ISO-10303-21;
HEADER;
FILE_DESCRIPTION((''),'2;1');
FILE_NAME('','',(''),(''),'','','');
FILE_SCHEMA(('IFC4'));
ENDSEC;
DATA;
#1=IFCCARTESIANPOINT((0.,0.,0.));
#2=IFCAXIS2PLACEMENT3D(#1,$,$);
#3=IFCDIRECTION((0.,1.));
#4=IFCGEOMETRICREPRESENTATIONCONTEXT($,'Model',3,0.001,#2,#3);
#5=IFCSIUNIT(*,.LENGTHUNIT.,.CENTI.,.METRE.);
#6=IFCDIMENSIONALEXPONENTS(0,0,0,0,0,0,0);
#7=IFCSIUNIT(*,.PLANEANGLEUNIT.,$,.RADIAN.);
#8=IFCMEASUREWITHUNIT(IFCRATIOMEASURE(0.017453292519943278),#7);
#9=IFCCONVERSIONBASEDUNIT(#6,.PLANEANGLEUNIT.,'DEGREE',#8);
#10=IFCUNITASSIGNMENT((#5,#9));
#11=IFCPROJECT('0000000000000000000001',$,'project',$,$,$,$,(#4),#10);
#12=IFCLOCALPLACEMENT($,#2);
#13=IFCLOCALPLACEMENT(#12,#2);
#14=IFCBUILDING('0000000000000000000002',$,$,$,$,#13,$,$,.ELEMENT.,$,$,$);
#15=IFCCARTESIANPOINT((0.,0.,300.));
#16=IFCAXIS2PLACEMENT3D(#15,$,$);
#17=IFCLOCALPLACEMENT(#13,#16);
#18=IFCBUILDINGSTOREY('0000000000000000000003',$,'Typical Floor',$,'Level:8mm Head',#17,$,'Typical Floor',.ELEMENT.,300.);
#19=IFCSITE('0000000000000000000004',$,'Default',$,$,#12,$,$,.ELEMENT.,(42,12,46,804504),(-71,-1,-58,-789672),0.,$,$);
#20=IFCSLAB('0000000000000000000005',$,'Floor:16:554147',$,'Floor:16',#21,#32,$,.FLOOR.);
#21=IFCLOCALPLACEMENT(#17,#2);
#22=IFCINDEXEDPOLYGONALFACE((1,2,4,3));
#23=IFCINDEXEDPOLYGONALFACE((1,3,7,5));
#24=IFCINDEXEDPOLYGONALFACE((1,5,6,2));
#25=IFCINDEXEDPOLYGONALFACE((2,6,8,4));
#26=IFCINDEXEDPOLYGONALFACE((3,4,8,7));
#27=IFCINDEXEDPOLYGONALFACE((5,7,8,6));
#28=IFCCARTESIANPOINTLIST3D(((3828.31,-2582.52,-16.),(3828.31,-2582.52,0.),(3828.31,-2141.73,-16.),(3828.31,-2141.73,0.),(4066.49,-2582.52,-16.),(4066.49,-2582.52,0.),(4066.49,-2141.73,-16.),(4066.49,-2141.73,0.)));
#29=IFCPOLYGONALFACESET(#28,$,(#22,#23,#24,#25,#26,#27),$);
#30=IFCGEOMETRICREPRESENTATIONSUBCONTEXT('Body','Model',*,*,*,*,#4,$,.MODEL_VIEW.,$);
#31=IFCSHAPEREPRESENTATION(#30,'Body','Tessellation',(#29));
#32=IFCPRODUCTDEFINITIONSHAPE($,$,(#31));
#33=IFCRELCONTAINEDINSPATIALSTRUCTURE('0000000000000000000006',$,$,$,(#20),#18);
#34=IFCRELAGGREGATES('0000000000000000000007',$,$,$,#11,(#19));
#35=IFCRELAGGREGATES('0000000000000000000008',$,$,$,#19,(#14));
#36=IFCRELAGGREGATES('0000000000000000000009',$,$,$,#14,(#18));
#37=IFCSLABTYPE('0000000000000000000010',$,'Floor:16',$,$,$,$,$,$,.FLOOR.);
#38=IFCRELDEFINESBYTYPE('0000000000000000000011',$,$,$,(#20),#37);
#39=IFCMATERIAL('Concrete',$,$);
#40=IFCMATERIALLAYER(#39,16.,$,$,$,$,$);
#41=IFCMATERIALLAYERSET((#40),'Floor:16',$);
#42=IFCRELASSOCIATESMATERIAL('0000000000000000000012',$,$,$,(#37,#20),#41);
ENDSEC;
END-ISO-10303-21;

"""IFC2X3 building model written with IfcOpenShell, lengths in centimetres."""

from ifc_helpers import new_model, entity, si_unit, converted_unit, direction, frame, frame_2d, origin, place, context, subcontext, project, spatial, rectangle, extrude, material, layer, layer_set, layer_usage, type_object, element, save


model = new_model("IFC2X3")

# Units and contexts
model_context = context("Model", 3, precision=0.001, world=origin(), true_north=direction((0.0, 1.0)))
body_context = subcontext(model_context, "Body", "Model", "MODEL_VIEW")
ifc_project = project(units=[si_unit("LENGTHUNIT", "METRE", prefix="CENTI"), converted_unit("PLANEANGLEUNIT", "DEGREE", entity("IfcRatioMeasure", 0.017453292519943278), si_unit("PLANEANGLEUNIT", "RADIAN"), dimensions=[0, 0, 0, 0, 0, 0, 0])], contexts=[model_context])

# Site, building, storey
site_placement = place(None, origin())
site = spatial("IfcSite", under=ifc_project, at=site_placement, Name="Default", CompositionType="ELEMENT", RefLatitude=(42, 12, 46, 804504), RefLongitude=(-71, -1, -58, -789672), RefElevation=0.0)
building_placement = place(site_placement, origin())
building = spatial("IfcBuilding", under=site, at=building_placement, CompositionType="ELEMENT")
storey_placement = place(building_placement, frame((0.0, 0.0, 300.0)))
storey = spatial("IfcBuildingStorey", under=building, at=storey_placement, Name="Typical Floor", ObjectType="Level:8mm Head", LongName="Typical Floor", CompositionType="ELEMENT", Elevation=300.0)

# Shared definitions
ifc_material = material(Name="Concrete")

# Slab
ifc_layer = layer(ifc_material, 16.0)
ifc_layer_set = layer_set([ifc_layer], Name="Floor:16")
ifc_layer_usage_1 = layer_usage(ifc_layer_set, "AXIS3", "POSITIVE", 0.0)
slab_type_1 = type_object("IfcSlabType", Name="Floor:16", PredefinedType="FLOOR", material=ifc_layer_set)
slab_1_placement = place(storey_placement, origin())
element("IfcSlab", 1, at=slab_1_placement, inside=storey, type_object=slab_type_1, material=ifc_layer_usage_1, Name="Floor:16:554147", ObjectType="Floor:16", PredefinedType="FLOOR", context=body_context, shape_type="SweptSolid", body=[
    extrude(rectangle(XDim=440.79, YDim=238.18, at=frame_2d((0.0, 0.0), x_axis=(1.0, 0.0))), frame((3947.4, -2362.13, 0.0), z_axis=(0.0, 0.0, -1.0), x_axis=(0.0, 1.0, 0.0)), (0.0, 0.0, 1.0), 16.0),
])

save(model, "model.ifc")
